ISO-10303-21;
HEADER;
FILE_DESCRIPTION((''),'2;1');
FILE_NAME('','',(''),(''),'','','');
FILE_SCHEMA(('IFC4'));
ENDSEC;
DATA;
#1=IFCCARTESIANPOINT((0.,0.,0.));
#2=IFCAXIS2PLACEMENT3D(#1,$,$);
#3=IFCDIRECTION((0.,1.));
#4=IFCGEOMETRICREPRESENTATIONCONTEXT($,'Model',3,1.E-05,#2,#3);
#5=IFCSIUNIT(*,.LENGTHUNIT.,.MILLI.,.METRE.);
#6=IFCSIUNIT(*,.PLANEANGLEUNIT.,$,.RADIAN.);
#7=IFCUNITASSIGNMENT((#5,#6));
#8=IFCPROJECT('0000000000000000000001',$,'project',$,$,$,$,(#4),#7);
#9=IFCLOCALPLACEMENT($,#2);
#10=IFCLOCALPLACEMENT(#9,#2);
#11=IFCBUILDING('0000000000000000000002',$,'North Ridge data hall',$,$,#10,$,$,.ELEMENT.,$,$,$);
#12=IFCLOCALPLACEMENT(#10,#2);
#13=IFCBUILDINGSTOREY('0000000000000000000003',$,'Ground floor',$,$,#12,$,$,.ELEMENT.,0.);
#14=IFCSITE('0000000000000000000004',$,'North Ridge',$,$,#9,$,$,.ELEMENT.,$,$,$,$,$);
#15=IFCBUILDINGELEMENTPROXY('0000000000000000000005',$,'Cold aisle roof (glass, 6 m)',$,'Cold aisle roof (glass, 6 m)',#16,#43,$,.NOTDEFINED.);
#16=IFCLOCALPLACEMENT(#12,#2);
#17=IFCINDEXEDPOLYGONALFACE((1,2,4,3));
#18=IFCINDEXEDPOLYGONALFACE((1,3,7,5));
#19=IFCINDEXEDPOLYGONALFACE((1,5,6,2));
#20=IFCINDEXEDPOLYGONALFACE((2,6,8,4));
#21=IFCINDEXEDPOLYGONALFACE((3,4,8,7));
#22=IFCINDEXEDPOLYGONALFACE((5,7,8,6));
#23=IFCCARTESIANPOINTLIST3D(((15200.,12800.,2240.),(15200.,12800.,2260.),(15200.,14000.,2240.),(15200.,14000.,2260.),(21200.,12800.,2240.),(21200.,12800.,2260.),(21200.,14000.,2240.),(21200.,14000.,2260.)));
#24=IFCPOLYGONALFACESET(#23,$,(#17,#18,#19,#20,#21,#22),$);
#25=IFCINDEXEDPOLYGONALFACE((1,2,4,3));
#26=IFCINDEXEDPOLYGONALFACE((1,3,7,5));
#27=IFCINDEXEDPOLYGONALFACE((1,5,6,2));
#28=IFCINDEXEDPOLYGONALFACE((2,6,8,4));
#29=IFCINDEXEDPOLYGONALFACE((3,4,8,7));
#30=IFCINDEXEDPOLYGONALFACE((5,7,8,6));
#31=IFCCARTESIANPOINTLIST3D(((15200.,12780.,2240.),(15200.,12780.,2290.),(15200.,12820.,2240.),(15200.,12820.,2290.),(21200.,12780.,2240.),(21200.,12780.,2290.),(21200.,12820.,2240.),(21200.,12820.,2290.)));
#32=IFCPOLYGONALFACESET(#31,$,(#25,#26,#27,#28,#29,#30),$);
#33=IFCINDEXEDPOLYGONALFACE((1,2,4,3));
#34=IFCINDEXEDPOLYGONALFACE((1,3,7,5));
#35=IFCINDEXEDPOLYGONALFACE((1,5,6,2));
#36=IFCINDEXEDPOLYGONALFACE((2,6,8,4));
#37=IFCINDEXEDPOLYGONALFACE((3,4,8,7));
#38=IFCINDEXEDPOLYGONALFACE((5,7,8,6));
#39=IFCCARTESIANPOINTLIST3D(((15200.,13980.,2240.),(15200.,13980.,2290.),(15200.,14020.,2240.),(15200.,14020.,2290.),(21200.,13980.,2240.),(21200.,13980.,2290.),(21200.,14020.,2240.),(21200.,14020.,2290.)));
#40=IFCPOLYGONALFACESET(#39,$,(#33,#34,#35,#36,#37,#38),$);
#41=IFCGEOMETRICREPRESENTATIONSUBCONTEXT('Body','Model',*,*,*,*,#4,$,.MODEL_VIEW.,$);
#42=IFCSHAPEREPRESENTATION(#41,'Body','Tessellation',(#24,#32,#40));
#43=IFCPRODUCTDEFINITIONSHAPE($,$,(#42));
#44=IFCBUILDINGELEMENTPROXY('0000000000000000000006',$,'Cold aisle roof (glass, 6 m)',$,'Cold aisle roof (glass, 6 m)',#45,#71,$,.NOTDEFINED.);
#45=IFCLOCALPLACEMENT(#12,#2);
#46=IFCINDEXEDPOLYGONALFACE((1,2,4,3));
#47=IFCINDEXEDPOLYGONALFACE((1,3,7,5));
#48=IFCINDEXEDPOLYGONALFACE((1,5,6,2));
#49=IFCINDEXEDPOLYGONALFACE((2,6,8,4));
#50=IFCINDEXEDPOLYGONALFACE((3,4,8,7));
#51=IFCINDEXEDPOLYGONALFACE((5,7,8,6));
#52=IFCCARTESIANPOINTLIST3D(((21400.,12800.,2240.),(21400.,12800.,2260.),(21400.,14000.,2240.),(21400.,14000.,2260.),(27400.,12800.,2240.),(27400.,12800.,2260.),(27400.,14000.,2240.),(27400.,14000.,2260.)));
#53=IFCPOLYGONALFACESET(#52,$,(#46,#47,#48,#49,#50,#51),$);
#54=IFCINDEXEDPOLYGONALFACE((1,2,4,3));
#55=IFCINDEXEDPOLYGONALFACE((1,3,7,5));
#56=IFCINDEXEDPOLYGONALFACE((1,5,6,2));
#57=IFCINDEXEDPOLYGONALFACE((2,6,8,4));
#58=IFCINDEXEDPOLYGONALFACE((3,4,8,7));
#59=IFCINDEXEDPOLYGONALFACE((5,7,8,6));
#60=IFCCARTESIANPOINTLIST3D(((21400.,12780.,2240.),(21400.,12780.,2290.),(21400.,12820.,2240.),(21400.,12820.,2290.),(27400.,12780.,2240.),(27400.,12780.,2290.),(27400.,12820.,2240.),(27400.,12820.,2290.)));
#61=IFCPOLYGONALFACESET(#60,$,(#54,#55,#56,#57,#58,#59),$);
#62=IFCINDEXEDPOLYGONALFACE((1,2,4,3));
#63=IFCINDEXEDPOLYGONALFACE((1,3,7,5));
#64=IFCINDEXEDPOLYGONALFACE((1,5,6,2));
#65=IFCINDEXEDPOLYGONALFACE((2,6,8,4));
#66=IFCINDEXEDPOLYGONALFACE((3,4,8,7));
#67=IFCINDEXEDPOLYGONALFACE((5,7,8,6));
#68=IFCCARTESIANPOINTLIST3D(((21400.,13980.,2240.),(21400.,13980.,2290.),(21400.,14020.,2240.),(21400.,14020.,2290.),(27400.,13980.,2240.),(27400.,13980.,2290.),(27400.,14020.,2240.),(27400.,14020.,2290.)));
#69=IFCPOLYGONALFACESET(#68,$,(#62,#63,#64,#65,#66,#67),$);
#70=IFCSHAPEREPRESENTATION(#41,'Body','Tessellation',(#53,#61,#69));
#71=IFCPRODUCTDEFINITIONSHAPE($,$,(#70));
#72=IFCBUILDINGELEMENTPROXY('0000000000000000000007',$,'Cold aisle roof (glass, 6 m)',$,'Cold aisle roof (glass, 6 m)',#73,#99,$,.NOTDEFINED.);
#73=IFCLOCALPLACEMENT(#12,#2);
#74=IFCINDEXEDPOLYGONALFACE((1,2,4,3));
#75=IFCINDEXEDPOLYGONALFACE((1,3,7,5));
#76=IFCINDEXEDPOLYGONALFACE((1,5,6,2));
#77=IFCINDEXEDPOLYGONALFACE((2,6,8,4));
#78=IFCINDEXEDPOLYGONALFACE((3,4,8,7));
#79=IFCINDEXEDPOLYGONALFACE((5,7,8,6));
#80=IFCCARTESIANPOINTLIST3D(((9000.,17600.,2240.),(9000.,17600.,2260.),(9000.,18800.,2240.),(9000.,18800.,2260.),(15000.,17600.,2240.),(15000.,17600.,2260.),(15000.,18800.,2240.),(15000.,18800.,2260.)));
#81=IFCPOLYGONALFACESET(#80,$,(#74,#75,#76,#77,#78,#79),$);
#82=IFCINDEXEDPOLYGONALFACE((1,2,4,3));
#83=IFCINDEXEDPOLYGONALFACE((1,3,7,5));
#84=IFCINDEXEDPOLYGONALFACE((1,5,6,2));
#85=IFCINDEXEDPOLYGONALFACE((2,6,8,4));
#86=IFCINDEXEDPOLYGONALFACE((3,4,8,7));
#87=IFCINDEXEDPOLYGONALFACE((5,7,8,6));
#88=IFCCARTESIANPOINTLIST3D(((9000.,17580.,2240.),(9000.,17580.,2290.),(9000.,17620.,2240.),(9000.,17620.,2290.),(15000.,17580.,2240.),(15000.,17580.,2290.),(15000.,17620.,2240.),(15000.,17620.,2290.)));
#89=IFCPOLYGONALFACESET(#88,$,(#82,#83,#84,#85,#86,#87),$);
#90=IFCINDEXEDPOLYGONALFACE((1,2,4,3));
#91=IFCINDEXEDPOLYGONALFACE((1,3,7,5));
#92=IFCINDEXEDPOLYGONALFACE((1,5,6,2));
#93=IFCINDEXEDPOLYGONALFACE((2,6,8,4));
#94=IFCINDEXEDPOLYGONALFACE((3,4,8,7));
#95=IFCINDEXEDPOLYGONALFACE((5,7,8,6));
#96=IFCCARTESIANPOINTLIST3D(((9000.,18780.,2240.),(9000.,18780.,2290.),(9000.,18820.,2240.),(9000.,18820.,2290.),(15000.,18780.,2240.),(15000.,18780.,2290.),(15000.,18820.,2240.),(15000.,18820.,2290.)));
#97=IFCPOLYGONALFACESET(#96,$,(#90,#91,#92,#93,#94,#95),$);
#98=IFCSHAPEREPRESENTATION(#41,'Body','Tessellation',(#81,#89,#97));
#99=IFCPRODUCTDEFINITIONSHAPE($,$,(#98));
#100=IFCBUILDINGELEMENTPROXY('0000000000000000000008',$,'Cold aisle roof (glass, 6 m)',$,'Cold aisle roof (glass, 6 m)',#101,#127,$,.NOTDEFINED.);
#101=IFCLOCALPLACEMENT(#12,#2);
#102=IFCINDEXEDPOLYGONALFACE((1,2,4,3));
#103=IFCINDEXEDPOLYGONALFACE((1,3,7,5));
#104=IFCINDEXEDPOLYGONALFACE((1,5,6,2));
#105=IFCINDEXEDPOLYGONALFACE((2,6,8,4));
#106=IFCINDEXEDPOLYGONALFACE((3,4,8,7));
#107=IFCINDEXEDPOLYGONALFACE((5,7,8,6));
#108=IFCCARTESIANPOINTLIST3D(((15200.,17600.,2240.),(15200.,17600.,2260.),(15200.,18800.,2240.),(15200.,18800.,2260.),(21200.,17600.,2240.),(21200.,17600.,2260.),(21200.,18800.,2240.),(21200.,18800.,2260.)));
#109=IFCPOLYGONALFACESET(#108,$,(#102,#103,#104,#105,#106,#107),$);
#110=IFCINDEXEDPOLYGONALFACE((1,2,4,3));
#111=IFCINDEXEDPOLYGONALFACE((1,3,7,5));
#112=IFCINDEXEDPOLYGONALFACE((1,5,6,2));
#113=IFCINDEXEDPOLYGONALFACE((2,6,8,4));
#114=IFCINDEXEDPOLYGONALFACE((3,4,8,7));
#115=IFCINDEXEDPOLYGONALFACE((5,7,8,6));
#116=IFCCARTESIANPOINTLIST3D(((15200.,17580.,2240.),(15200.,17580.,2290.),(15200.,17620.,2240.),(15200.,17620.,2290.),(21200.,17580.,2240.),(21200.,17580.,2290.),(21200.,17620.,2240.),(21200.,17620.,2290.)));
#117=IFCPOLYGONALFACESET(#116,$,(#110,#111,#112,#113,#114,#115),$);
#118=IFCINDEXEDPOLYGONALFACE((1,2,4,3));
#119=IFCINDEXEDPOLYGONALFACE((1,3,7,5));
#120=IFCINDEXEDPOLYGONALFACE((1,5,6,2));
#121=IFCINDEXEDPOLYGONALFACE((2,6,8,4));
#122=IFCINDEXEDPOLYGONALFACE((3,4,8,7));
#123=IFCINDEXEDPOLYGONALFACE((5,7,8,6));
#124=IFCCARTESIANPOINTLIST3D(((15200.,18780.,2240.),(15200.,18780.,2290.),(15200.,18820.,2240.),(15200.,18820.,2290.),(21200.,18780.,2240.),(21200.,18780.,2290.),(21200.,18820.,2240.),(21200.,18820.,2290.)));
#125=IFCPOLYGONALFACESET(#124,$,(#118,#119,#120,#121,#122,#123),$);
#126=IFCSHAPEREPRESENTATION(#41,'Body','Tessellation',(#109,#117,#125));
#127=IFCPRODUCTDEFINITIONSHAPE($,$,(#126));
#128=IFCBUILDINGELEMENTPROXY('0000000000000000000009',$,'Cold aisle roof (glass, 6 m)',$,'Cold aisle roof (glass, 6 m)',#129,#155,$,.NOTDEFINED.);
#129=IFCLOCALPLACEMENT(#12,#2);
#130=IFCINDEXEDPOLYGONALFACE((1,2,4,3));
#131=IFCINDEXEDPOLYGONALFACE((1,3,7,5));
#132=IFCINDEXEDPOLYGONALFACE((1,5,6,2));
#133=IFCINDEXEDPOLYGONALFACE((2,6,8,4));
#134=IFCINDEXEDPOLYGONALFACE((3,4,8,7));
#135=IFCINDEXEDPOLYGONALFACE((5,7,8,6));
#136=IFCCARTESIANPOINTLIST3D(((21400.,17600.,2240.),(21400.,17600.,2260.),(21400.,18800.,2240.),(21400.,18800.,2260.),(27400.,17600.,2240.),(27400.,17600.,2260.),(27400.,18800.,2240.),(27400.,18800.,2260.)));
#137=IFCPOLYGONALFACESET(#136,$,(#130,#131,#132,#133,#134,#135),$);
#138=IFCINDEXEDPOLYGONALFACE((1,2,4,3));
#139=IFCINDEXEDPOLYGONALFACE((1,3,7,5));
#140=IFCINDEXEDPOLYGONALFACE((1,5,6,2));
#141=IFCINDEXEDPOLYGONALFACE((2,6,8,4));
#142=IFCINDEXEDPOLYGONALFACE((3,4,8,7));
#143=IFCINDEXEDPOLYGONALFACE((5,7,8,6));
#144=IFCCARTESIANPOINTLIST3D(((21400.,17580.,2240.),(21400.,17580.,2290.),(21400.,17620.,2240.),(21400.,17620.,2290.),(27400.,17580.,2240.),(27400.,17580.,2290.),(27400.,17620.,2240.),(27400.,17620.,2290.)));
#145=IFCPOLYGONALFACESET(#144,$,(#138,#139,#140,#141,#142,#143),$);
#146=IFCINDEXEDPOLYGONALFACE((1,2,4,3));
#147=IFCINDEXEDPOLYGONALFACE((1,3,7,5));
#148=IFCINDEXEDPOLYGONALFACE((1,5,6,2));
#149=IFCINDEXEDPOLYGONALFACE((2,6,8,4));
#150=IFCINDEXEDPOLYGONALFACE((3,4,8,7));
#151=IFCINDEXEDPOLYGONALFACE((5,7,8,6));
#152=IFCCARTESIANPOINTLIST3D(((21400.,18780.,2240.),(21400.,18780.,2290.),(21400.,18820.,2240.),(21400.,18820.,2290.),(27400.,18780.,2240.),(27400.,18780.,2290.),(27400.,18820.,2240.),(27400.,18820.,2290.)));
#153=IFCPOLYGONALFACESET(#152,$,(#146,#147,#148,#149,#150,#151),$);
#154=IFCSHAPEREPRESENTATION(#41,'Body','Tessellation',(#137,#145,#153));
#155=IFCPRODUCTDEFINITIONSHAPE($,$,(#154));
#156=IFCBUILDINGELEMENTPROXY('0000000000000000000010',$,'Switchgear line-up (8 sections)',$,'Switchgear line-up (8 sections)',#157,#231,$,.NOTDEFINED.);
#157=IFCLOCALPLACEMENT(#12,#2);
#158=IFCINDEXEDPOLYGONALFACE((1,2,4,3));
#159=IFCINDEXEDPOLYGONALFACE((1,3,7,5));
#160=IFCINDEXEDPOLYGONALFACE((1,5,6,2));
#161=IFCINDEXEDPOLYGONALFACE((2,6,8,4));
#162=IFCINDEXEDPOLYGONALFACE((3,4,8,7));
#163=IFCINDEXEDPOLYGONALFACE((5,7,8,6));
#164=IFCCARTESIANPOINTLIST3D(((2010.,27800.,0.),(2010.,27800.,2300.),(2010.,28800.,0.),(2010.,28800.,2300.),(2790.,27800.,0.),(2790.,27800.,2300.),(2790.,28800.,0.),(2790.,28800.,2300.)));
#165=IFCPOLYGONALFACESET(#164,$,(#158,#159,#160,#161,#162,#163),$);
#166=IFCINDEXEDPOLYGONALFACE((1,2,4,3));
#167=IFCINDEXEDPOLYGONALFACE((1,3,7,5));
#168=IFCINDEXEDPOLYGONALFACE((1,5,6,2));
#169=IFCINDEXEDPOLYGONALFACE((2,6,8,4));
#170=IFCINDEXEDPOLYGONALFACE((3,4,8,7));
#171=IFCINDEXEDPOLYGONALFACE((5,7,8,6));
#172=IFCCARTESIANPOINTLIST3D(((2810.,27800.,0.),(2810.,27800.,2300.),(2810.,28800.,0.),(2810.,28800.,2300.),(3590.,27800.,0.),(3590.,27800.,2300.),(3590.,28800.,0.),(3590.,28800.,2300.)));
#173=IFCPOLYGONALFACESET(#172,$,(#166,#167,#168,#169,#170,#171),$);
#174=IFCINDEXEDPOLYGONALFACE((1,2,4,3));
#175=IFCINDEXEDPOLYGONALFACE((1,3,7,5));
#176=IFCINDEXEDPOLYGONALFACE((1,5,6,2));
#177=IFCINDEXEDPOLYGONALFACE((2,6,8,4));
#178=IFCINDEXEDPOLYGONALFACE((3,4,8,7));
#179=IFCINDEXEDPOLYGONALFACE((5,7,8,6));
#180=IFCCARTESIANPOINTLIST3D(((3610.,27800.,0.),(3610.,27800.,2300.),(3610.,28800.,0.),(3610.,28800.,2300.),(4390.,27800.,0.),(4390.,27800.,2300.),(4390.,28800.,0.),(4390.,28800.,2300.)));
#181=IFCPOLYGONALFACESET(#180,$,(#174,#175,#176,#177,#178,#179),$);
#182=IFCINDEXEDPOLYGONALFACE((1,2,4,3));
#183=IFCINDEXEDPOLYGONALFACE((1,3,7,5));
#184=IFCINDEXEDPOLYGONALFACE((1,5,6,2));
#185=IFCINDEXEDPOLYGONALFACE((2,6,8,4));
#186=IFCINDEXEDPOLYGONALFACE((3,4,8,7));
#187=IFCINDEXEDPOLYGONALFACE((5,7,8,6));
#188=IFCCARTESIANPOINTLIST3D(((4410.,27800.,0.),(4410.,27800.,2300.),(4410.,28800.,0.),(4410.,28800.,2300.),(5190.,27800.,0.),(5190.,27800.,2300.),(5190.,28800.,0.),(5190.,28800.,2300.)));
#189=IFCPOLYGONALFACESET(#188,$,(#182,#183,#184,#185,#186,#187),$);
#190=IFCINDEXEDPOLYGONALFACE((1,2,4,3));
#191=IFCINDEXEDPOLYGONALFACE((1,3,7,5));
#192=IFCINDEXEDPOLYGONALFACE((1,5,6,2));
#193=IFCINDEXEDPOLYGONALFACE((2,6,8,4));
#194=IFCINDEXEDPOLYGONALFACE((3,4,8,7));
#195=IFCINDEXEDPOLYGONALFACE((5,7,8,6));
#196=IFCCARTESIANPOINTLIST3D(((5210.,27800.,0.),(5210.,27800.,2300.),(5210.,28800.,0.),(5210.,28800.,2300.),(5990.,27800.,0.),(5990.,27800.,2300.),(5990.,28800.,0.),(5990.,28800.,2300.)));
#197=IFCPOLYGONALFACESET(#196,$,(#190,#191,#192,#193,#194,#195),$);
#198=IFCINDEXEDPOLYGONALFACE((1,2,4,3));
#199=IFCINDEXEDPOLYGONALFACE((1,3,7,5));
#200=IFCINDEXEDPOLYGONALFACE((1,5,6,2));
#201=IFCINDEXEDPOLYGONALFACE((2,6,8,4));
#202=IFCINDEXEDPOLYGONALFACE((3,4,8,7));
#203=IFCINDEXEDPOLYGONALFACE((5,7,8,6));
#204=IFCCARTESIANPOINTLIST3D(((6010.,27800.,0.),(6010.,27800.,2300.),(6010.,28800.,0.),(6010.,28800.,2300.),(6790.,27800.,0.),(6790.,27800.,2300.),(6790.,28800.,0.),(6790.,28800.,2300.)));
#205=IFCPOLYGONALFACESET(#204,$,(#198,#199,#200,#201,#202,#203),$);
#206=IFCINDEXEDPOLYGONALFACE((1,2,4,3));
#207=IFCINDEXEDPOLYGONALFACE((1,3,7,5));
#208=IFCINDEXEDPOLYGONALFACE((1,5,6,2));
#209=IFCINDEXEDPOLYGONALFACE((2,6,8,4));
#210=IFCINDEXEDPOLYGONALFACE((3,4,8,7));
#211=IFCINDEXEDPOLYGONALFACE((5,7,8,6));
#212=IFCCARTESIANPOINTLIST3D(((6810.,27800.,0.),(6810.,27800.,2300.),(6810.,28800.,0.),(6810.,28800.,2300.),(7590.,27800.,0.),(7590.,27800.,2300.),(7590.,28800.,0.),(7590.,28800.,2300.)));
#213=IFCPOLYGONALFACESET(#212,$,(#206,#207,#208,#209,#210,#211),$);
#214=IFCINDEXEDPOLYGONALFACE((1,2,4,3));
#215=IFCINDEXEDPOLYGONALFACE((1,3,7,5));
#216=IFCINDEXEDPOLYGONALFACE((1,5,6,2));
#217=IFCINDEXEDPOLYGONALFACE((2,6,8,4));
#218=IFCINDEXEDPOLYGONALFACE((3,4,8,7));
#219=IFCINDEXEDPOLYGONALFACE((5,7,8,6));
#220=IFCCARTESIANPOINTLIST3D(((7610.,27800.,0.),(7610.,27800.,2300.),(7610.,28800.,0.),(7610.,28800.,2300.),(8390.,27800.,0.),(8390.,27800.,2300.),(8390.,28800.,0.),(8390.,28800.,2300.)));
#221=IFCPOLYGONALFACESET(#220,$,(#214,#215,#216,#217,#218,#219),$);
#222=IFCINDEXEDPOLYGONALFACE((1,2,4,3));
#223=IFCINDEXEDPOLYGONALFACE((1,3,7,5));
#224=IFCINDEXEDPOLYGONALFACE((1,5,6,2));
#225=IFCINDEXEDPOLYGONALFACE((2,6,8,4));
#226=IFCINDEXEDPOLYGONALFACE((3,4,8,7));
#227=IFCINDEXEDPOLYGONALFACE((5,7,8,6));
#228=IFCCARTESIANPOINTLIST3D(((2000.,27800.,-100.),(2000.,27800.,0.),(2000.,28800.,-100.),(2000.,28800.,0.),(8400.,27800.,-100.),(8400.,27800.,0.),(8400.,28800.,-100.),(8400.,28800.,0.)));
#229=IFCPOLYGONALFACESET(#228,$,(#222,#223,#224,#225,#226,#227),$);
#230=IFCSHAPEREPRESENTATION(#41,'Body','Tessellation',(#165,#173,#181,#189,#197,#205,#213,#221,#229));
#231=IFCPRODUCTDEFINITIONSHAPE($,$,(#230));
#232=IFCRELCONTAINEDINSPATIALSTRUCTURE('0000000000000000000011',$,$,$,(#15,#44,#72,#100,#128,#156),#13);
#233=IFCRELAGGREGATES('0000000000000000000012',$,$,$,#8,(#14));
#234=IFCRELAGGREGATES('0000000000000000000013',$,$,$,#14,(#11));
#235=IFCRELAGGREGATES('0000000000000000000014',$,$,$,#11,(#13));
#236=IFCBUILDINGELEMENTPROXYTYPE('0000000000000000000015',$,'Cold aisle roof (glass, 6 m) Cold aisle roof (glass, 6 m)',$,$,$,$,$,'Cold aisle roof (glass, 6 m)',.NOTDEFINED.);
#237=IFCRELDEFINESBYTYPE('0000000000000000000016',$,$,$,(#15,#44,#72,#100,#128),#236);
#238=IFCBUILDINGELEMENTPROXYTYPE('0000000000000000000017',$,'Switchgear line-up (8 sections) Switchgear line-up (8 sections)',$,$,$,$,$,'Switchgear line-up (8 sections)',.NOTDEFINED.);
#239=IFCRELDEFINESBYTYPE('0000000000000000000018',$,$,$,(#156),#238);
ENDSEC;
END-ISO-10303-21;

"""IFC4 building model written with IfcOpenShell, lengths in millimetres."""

from ifc_helpers import new_model, si_unit, direction, frame, origin, place, context, subcontext, project, spatial, polyline, outline, extrude, source, transform, mapped, type_object, type_shapes, element, save


model = new_model("IFC4")

# Units and contexts
model_context = context("Model", 3, precision=1e-05, world=origin(), true_north=direction((0.0, 1.0)))
body_context = subcontext(model_context, "Body", "Model", "MODEL_VIEW")
ifc_project = project(units=[si_unit("LENGTHUNIT", "METRE", prefix="MILLI"), si_unit("PLANEANGLEUNIT", "RADIAN")], contexts=[model_context])

# Site, building, storey
site_placement = place(None, origin())
site = spatial("IfcSite", under=ifc_project, at=site_placement, Name="North Ridge", CompositionType="ELEMENT")
building_placement = place(site_placement, origin())
building = spatial("IfcBuilding", under=site, at=building_placement, Name="North Ridge data hall", CompositionType="ELEMENT")
storey_placement = place(building_placement, origin())
storey = spatial("IfcBuildingStorey", under=building, at=storey_placement, Name="Ground floor", CompositionType="ELEMENT", Elevation=0.0)

# Building element proxies
building_element_proxy_type_1 = type_object("IfcBuildingElementProxyType", Name="Cold aisle roof (glass, 6 m) Cold aisle roof (glass, 6 m)", ElementType="Cold aisle roof (glass, 6 m)", PredefinedType="NOTDEFINED")
shared_shape_1 = source(origin(), body_context, "Body", "SweptSolid", [
    extrude(outline(polyline([(0.0, 0.0), (6000.0, 0.0), (6000.0, 1200.0), (0.0, 1200.0), (0.0, 0.0)])), frame((0.0, 0.0, 2240.0)), (0.0, 0.0, 1.0), 20.0),
    extrude(outline(polyline([(0.0, -20.0), (6000.0, -20.0), (6000.0, 20.0), (0.0, 20.0), (0.0, -20.0)])), frame((0.0, 0.0, 2240.0)), (0.0, 0.0, 1.0), 50.0),
    extrude(outline(polyline([(0.0, 1180.0), (6000.0, 1180.0), (6000.0, 1220.0), (0.0, 1220.0), (0.0, 1180.0)])), frame((0.0, 0.0, 2240.0)), (0.0, 0.0, 1.0), 50.0),
])
type_shapes(building_element_proxy_type_1, [shared_shape_1])
for number, where, z_axis, x_axis, name in (
    (1, (15200.0, 12800.0, 0.0), (0.0, 0.0, 1.0), (1.0, 0.0, 0.0), "Cold aisle roof (glass, 6 m)"),
    (2, (21400.0, 12800.0, 0.0), (0.0, 0.0, 1.0), (1.0, 0.0, 0.0), "Cold aisle roof (glass, 6 m)"),
    (3, (9000.0, 17600.0, 0.0), (0.0, 0.0, 1.0), (1.0, 0.0, 0.0), "Cold aisle roof (glass, 6 m)"),
    (4, (15200.0, 17600.0, 0.0), (0.0, 0.0, 1.0), (1.0, 0.0, 0.0), "Cold aisle roof (glass, 6 m)"),
    (5, (21400.0, 17600.0, 0.0), (0.0, 0.0, 1.0), (1.0, 0.0, 0.0), "Cold aisle roof (glass, 6 m)"),
):
    element("IfcBuildingElementProxy", number, at=place(storey_placement, frame(where, z_axis=z_axis, x_axis=x_axis)), inside=storey, type_object=building_element_proxy_type_1, Name=name, ObjectType="Cold aisle roof (glass, 6 m)", PredefinedType="NOTDEFINED", context=body_context, shape_type="MappedRepresentation", body=[
        mapped(shared_shape_1, transform((0.0, 0.0, 0.0))),
    ])
building_element_proxy_type_2 = type_object("IfcBuildingElementProxyType", Name="Switchgear line-up (8 sections) Switchgear line-up (8 sections)", ElementType="Switchgear line-up (8 sections)", PredefinedType="NOTDEFINED")
shared_shape_2 = source(origin(), body_context, "Body", "SweptSolid", [
    extrude(outline(polyline([(10.0, 0.0), (790.0, 0.0), (790.0, 1000.0), (10.0, 1000.0), (10.0, 0.0)])), origin(), (0.0, 0.0, 1.0), 2300.0),
    extrude(outline(polyline([(810.0, 0.0), (1590.0, 0.0), (1590.0, 1000.0), (810.0, 1000.0), (810.0, 0.0)])), origin(), (0.0, 0.0, 1.0), 2300.0),
    extrude(outline(polyline([(1610.0, 0.0), (2390.0, 0.0), (2390.0, 1000.0), (1610.0, 1000.0), (1610.0, 0.0)])), origin(), (0.0, 0.0, 1.0), 2300.0),
    extrude(outline(polyline([(2410.0, 0.0), (3190.0, 0.0), (3190.0, 1000.0), (2410.0, 1000.0), (2410.0, 0.0)])), origin(), (0.0, 0.0, 1.0), 2300.0),
    extrude(outline(polyline([(3210.0, 0.0), (3990.0, 0.0), (3990.0, 1000.0), (3210.0, 1000.0), (3210.0, 0.0)])), origin(), (0.0, 0.0, 1.0), 2300.0),
    extrude(outline(polyline([(4010.0, 0.0), (4790.0, 0.0), (4790.0, 1000.0), (4010.0, 1000.0), (4010.0, 0.0)])), origin(), (0.0, 0.0, 1.0), 2300.0),
    extrude(outline(polyline([(4810.0, 0.0), (5590.0, 0.0), (5590.0, 1000.0), (4810.0, 1000.0), (4810.0, 0.0)])), origin(), (0.0, 0.0, 1.0), 2300.0),
    extrude(outline(polyline([(5610.0, 0.0), (6390.0, 0.0), (6390.0, 1000.0), (5610.0, 1000.0), (5610.0, 0.0)])), origin(), (0.0, 0.0, 1.0), 2300.0),
    extrude(outline(polyline([(0.0, 0.0), (6400.0, 0.0), (6400.0, 1000.0), (0.0, 1000.0), (0.0, 0.0)])), frame((0.0, 0.0, -100.0)), (0.0, 0.0, 1.0), 100.0),
])
type_shapes(building_element_proxy_type_2, [shared_shape_2])
for number, where, z_axis, x_axis, name in (
    (6, (2000.0, 27800.0, 0.0), (0.0, 0.0, 1.0), (1.0, 0.0, 0.0), "Switchgear line-up (8 sections)"),
):
    element("IfcBuildingElementProxy", number, at=place(storey_placement, frame(where, z_axis=z_axis, x_axis=x_axis)), inside=storey, type_object=building_element_proxy_type_2, Name=name, ObjectType="Switchgear line-up (8 sections)", PredefinedType="NOTDEFINED", context=body_context, shape_type="MappedRepresentation", body=[
        mapped(shared_shape_2, transform((0.0, 0.0, 0.0))),
    ])

save(model, "model.ifc")
